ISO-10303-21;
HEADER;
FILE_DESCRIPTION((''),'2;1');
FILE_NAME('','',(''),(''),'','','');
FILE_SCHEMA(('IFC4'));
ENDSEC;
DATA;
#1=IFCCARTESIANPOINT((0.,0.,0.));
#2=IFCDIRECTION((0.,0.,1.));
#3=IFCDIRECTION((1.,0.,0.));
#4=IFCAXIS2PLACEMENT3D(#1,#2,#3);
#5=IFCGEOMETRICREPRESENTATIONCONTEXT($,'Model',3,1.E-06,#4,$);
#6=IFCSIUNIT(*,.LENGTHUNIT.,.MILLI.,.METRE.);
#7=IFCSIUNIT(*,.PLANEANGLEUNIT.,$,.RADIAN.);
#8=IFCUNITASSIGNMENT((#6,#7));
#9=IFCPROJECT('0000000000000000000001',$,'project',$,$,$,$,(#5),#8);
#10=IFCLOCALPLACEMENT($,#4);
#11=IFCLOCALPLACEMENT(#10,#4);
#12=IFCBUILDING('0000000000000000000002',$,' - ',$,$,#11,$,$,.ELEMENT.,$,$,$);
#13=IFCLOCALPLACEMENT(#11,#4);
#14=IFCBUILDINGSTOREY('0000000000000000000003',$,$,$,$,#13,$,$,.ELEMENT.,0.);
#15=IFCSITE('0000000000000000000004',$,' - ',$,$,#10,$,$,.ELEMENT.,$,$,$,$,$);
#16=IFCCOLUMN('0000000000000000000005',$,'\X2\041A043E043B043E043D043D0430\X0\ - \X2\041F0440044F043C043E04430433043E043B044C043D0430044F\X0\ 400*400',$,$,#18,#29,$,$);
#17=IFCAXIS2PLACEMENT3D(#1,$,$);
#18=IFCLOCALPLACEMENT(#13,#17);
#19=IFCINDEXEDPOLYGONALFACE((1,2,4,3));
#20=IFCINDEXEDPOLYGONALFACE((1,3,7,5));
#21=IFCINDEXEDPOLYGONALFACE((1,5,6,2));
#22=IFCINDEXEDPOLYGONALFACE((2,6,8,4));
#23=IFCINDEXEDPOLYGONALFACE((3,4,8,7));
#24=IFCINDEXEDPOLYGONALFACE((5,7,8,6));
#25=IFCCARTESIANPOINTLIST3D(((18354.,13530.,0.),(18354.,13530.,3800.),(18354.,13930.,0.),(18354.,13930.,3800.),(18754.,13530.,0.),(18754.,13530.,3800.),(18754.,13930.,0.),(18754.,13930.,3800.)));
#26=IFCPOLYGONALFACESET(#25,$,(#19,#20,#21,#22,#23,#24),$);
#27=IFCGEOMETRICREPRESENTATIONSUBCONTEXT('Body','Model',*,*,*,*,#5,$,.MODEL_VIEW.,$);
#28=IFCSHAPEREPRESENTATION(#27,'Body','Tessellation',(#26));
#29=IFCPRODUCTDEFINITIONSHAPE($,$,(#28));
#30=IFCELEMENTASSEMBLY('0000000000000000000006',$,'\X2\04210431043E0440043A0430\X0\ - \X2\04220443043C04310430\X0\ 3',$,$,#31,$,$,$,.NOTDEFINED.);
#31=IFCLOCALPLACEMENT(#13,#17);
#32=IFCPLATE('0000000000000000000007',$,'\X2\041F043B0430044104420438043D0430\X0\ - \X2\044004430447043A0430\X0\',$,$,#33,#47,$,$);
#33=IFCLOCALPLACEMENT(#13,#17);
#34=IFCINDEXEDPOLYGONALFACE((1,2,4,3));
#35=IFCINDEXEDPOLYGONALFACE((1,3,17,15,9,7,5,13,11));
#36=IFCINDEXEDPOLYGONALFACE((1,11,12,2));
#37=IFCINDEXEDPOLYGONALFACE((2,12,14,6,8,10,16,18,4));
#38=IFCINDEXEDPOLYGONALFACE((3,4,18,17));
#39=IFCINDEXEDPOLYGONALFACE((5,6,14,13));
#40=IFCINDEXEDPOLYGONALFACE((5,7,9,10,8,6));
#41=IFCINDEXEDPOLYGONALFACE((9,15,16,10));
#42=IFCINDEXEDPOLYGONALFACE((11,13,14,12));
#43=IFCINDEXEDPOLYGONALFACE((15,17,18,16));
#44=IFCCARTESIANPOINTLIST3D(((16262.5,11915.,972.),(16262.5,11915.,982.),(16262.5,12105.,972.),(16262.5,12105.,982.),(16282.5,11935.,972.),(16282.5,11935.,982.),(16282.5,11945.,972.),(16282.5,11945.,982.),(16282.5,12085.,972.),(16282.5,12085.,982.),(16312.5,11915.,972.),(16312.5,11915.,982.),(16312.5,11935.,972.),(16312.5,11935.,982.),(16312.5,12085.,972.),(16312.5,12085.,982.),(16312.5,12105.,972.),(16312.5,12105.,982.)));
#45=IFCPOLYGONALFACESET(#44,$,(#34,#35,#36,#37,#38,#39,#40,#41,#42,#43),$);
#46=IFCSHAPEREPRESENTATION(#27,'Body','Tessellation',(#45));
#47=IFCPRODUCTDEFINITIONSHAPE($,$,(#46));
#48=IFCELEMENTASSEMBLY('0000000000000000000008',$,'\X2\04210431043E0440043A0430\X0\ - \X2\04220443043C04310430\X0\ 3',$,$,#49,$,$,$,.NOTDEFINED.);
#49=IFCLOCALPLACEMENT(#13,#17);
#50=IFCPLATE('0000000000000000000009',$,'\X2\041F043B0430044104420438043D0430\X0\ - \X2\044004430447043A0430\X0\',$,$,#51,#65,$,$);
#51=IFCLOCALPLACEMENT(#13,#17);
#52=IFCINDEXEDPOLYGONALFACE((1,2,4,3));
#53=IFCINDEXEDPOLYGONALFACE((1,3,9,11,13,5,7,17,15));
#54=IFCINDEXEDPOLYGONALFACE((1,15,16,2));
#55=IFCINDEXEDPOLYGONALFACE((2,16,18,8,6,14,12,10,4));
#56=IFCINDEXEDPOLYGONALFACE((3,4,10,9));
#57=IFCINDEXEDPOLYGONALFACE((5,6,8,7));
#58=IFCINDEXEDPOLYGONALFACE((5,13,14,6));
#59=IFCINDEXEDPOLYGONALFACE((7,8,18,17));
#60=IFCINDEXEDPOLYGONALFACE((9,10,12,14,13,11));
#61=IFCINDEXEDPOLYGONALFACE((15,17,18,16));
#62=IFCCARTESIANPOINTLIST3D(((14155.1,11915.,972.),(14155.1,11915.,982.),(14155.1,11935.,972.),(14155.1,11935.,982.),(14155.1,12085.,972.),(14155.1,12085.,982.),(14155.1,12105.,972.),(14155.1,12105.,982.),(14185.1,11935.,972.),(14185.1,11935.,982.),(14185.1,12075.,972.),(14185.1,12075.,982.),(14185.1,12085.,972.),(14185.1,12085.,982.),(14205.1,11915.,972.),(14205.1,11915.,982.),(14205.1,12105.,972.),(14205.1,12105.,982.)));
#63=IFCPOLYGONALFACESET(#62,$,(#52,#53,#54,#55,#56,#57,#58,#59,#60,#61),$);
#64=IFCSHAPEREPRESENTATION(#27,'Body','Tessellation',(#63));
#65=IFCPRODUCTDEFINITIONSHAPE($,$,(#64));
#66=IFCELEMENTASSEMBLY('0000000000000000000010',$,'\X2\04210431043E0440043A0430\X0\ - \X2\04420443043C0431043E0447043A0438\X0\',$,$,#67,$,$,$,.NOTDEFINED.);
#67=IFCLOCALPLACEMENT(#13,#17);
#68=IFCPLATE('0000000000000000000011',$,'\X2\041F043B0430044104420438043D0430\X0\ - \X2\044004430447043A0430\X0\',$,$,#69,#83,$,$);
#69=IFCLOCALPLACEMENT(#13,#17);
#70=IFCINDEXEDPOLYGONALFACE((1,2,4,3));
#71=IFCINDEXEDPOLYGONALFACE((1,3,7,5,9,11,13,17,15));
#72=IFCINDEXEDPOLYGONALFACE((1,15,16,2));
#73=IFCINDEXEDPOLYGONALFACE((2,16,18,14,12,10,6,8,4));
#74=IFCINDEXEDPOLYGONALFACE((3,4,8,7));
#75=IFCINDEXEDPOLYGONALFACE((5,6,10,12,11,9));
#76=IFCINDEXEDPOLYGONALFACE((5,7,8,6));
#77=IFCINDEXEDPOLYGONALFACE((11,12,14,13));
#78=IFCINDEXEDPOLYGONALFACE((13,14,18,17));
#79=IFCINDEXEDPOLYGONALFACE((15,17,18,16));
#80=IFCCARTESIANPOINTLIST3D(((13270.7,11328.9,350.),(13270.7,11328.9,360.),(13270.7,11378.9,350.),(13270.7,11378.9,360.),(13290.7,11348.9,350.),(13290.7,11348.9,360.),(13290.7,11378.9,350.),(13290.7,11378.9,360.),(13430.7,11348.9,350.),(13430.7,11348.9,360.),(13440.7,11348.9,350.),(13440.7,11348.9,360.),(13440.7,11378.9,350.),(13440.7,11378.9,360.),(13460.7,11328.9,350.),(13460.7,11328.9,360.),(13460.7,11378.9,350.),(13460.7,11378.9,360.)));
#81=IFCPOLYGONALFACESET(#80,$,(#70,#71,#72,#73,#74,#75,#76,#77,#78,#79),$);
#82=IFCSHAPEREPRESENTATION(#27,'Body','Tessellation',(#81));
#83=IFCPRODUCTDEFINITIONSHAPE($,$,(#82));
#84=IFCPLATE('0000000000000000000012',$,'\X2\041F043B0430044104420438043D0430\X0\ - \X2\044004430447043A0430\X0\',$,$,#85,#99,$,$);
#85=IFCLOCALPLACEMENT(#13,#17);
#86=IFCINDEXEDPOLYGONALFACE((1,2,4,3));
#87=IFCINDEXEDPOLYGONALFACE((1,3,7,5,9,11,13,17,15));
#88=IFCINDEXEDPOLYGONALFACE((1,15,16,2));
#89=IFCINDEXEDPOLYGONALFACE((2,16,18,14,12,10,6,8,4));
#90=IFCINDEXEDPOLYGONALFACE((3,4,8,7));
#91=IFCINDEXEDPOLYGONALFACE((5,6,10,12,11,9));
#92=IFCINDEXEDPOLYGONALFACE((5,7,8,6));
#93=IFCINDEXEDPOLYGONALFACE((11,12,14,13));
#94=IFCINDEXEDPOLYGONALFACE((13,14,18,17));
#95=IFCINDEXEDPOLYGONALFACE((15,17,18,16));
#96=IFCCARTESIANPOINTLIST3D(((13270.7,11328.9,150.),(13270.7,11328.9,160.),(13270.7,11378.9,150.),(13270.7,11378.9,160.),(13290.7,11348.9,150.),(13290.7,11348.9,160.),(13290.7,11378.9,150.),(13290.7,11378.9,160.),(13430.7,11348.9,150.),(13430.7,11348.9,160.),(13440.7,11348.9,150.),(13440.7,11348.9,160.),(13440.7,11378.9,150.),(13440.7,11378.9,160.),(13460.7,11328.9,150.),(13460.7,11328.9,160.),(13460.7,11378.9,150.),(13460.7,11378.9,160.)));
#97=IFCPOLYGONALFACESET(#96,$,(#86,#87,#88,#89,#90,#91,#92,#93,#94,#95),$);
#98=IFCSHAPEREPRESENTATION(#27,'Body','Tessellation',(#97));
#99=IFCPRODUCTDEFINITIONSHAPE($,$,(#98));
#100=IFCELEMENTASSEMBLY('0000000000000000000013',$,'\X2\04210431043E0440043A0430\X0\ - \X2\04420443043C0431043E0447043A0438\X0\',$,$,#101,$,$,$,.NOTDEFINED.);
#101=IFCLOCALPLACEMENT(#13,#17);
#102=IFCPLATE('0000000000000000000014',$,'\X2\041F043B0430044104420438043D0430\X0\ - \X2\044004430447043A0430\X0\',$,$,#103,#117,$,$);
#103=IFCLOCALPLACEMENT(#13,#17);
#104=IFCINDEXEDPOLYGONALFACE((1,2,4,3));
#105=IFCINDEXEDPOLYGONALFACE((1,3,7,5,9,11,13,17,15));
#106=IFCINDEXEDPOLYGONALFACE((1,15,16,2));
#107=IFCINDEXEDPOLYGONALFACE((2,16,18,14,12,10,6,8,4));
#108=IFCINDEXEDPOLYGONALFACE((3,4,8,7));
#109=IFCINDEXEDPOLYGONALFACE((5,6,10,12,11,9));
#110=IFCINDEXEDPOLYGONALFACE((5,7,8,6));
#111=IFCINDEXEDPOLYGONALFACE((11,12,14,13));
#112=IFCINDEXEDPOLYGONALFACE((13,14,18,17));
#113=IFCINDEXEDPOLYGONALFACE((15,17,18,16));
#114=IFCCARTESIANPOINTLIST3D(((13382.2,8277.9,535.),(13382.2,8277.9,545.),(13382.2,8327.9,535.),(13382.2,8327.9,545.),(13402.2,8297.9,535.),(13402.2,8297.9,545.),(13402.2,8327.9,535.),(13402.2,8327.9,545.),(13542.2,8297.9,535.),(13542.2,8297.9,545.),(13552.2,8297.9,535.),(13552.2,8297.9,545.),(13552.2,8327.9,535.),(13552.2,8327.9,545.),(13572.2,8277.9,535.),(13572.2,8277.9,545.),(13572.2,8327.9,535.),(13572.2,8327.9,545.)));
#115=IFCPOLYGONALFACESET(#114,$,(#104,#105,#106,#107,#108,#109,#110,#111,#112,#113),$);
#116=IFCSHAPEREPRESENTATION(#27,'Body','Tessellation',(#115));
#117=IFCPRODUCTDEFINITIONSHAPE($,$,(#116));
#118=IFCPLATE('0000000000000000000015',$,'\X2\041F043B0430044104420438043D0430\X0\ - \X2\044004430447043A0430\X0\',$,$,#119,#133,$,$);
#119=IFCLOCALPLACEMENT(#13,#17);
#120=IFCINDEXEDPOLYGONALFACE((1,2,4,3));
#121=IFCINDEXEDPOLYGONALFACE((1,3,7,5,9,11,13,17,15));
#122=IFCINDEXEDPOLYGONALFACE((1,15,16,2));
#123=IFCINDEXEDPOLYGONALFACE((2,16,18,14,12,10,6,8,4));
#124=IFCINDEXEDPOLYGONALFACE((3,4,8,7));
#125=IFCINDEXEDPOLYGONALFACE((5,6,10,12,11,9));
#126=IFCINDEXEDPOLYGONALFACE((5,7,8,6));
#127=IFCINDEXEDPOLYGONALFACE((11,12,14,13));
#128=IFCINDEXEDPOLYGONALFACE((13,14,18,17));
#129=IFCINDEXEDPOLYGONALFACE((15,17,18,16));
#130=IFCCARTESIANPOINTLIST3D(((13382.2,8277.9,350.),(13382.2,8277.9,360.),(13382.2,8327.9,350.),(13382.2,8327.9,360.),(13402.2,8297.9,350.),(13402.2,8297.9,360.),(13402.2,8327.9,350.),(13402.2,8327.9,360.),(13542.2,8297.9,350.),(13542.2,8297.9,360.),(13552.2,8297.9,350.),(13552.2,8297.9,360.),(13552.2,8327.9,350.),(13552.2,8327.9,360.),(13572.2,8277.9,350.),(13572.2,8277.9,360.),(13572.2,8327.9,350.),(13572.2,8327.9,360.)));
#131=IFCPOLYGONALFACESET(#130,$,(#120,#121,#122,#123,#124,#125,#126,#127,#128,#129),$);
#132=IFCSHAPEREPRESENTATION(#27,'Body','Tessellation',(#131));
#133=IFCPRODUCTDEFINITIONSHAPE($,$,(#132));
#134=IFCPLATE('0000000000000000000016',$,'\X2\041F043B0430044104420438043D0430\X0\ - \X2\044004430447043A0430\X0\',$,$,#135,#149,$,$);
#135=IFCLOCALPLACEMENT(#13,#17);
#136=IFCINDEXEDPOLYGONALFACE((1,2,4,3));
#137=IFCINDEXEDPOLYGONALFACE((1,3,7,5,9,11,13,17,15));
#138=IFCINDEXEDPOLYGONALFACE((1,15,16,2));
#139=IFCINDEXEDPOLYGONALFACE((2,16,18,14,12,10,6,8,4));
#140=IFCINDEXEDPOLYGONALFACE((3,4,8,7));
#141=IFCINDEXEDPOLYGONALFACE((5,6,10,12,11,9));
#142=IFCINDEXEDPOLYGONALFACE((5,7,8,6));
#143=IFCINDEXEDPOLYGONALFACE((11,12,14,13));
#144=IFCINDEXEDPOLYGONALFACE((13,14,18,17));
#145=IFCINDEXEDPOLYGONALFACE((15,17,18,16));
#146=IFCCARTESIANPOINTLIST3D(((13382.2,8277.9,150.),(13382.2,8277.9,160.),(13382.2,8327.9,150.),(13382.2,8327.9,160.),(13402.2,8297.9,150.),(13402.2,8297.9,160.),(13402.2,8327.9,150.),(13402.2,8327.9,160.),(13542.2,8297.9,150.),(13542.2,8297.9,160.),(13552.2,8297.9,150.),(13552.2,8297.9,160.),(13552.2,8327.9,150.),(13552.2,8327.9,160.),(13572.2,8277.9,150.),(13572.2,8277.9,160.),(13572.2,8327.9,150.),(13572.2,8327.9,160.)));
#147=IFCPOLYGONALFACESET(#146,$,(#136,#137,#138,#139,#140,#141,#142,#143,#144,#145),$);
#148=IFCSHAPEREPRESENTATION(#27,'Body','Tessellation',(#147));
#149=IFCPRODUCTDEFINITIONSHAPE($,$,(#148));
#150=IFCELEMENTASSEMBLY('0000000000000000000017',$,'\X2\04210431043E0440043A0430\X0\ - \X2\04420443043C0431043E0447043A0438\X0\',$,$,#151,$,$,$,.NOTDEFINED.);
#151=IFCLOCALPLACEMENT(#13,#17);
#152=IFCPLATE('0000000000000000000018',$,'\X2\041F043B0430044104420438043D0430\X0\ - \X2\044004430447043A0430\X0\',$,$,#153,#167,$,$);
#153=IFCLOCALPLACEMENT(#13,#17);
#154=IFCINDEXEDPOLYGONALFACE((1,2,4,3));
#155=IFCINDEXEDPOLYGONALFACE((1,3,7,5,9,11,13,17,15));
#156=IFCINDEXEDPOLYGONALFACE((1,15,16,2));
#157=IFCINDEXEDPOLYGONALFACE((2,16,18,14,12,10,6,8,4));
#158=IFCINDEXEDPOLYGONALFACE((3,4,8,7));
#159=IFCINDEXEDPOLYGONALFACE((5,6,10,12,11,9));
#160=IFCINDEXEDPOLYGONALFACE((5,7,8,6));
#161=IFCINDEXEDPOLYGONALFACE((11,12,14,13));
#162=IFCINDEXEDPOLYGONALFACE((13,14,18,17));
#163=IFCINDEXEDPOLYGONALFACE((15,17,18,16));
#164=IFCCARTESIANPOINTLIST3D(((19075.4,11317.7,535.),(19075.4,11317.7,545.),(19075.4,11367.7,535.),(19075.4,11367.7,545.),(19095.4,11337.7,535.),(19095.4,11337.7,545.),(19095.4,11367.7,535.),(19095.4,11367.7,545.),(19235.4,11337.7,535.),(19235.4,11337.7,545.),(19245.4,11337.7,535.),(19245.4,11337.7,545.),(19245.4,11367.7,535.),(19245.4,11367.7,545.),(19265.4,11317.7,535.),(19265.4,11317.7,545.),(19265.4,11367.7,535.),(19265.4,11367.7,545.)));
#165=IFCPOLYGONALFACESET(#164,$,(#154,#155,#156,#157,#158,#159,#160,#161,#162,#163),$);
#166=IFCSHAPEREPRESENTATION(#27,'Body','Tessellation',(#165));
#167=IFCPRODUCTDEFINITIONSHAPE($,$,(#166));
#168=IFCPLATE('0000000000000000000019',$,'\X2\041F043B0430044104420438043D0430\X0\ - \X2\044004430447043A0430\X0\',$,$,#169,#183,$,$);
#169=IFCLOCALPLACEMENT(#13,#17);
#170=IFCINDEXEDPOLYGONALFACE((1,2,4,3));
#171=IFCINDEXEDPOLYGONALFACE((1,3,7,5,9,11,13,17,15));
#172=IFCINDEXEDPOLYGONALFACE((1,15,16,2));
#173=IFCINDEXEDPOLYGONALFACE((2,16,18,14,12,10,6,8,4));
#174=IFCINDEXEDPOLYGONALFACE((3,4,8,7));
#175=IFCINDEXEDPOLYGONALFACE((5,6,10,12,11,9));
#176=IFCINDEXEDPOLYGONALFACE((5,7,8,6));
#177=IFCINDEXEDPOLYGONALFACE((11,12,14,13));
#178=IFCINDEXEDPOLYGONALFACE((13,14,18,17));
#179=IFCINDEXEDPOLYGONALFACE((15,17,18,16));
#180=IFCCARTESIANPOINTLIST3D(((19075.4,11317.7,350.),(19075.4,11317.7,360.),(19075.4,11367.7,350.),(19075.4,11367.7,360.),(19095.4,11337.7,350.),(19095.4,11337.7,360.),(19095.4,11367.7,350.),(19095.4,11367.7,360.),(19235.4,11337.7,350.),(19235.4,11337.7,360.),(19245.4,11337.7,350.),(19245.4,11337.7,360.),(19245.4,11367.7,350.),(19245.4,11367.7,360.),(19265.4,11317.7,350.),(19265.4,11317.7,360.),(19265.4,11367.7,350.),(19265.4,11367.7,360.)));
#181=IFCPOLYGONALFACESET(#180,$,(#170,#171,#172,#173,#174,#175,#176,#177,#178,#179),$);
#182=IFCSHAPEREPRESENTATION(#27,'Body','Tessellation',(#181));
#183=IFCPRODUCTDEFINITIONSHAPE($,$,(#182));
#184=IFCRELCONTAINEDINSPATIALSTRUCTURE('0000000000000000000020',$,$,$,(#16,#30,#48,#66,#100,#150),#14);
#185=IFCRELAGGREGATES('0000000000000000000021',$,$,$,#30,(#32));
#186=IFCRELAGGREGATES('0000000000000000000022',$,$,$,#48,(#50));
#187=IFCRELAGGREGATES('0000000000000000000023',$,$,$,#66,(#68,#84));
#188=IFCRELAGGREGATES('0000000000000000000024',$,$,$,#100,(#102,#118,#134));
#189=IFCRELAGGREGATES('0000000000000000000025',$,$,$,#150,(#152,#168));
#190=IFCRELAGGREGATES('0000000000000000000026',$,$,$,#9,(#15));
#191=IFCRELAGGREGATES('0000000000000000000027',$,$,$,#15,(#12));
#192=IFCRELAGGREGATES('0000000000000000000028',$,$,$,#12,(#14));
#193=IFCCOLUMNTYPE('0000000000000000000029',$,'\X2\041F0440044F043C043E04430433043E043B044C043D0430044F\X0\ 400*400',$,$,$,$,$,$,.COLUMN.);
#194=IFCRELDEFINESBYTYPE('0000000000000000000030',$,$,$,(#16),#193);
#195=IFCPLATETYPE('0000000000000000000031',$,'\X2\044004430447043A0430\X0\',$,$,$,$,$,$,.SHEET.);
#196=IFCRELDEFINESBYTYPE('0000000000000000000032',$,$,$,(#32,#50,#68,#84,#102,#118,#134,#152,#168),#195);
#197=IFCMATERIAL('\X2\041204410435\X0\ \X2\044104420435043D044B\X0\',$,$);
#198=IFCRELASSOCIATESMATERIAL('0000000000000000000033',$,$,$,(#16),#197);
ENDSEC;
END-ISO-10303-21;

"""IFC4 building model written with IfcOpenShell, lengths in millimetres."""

from ifc_helpers import new_model, si_unit, frame, origin_with_axes, place, context, subcontext, project, spatial, line, indexed_curve, outline, extrude, source, transform, mapped, material, type_object, element, aggregate, save


model = new_model("IFC4")

# Units and contexts
model_context = context("Model", 3, precision=1e-06, world=origin_with_axes())
body_context = subcontext(model_context, "Body", "Model", "MODEL_VIEW")
ifc_project = project(units=[si_unit("LENGTHUNIT", "METRE", prefix="MILLI"), si_unit("PLANEANGLEUNIT", "RADIAN")], contexts=[model_context])

# Site, building, storey
site_placement = place(None, origin_with_axes())
site = spatial("IfcSite", under=ifc_project, at=site_placement, Name=" - ", CompositionType="ELEMENT")
building_placement = place(site_placement, origin_with_axes())
building = spatial("IfcBuilding", under=site, at=building_placement, Name=" - ", CompositionType="ELEMENT")
storey_placement = place(building_placement, origin_with_axes())
storey = spatial("IfcBuildingStorey", under=building, at=storey_placement, CompositionType="ELEMENT", Elevation=0.0)

# Column
ifc_material = material(Name="Все стены")
column_type = type_object("IfcColumnType", Name="Прямоугольная 400*400", PredefinedType="COLUMN")
shared_shape_1 = source(origin_with_axes(), body_context, "Body", "SweptSolid", [
    extrude(outline(indexed_curve([(-200.0, -200.0), (200.0, -200.0), (200.0, 200.0), (-200.0, 200.0)], segments=[line(1, 2), line(2, 3), line(3, 4), line(4, 1)])), origin_with_axes(), (0.0, 0.0, 1.0), 3800.0),
])
column_placement = place(storey_placement, frame((18554.0, 13730.0, 0.0), z_axis=(0.0, 0.0, 1.0), x_axis=(1.0, 0.0, 0.0)))
element("IfcColumn", 1, at=column_placement, inside=storey, type_object=column_type, material=ifc_material, Name="Колонна - Прямоугольная 400*400", context=body_context, shape_type="MappedRepresentation", body=[
    mapped(shared_shape_1, transform((0.0, 0.0, 0.0), x_axis=(1.0, 0.0, 0.0), y_axis=(0.0, 1.0, 0.0), z_axis=(0.0, 0.0, 1.0), scale=1.0)),
])

# Element assemblies, plates
assembly_1_placement = place(storey_placement, frame((16502.5, 12010.0, 2.0), z_axis=(0.0, 0.0, 1.0), x_axis=(0.0, -1.0, 0.0)))
assembly_1 = element("IfcElementAssembly", 2, at=assembly_1_placement, inside=storey, Name="Сборка - Тумба 3", PredefinedType="NOTDEFINED")
plate_type_1 = type_object("IfcPlateType", Name="ручка", PredefinedType="SHEET")
shared_shape_2 = source(origin_with_axes(), body_context, "Body", "SweptSolid", [
    extrude(outline(indexed_curve([(-95.0, -25.0), (-75.0, -25.0), (-75.0, 5.0), (-65.0, 5.0), (75.0, 5.0), (75.0, -25.0), (95.0, -25.0), (95.0, 25.0), (-95.0, 25.0)], segments=[line(1, 2), line(2, 3), line(3, 4), line(4, 5), line(5, 6), line(6, 7), line(7, 8), line(8, 9), line(9, 1)])), origin_with_axes(), (0.0, 0.0, 1.0), 10.0),
])
plate_1_placement = place(assembly_1_placement, frame((0.0, -215.0, 970.0), z_axis=(0.0, 0.0, 1.0), x_axis=(-1.0, 0.0, 0.0)))
plate_1 = element("IfcPlate", 3, at=plate_1_placement, type_object=plate_type_1, Name="Пластина - ручка", context=body_context, shape_type="MappedRepresentation", body=[
    mapped(shared_shape_2, transform((0.0, 0.0, 0.0), x_axis=(1.0, 0.0, 0.0), y_axis=(0.0, 1.0, 0.0), z_axis=(0.0, 0.0, 1.0), scale=1.0)),
])
aggregate(assembly_1, [plate_1])
assembly_2_placement = place(storey_placement, frame((13965.1, 12010.0, 2.0), z_axis=(0.0, 0.0, 1.0), x_axis=(0.0, 1.0, 0.0)))
assembly_2 = element("IfcElementAssembly", 4, at=assembly_2_placement, inside=storey, Name="Сборка - Тумба 3", PredefinedType="NOTDEFINED")
plate_2_placement = place(assembly_2_placement, frame((0.0, -215.0, 970.0), z_axis=(0.0, 0.0, 1.0), x_axis=(-1.0, 0.0, 0.0)))
plate_2 = element("IfcPlate", 5, at=plate_2_placement, type_object=plate_type_1, Name="Пластина - ручка", context=body_context, shape_type="MappedRepresentation", body=[
    mapped(shared_shape_2, transform((0.0, 0.0, 0.0), x_axis=(1.0, 0.0, 0.0), y_axis=(0.0, 1.0, 0.0), z_axis=(0.0, 0.0, 1.0), scale=1.0)),
])
aggregate(assembly_2, [plate_2])
assembly_3_placement = place(storey_placement, frame((13165.7, 11378.9, 0.0), z_axis=(0.0, 0.0, 1.0), x_axis=(1.0, 0.0, 0.0)))
assembly_3 = element("IfcElementAssembly", 6, at=assembly_3_placement, inside=storey, Name="Сборка - тумбочки", PredefinedType="NOTDEFINED")
plate_3_placement = place(assembly_3_placement, frame((200.0, -25.0, 350.0), z_axis=(0.0, 0.0, 1.0), x_axis=(-1.0, 0.0, 0.0)))
plate_3 = element("IfcPlate", 7, at=plate_3_placement, type_object=plate_type_1, Name="Пластина - ручка", context=body_context, shape_type="MappedRepresentation", body=[
    mapped(shared_shape_2, transform((0.0, 0.0, 0.0), x_axis=(1.0, 0.0, 0.0), y_axis=(0.0, 1.0, 0.0), z_axis=(0.0, 0.0, 1.0), scale=1.0)),
])
plate_4_placement = place(assembly_3_placement, frame((200.0, -25.0, 150.0), z_axis=(0.0, 0.0, 1.0), x_axis=(-1.0, 0.0, 0.0)))
plate_4 = element("IfcPlate", 8, at=plate_4_placement, type_object=plate_type_1, Name="Пластина - ручка", context=body_context, shape_type="MappedRepresentation", body=[
    mapped(shared_shape_2, transform((0.0, 0.0, 0.0), x_axis=(1.0, 0.0, 0.0), y_axis=(0.0, 1.0, 0.0), z_axis=(0.0, 0.0, 1.0), scale=1.0)),
])
aggregate(assembly_3, [plate_3, plate_4])
assembly_4_placement = place(storey_placement, frame((13277.2, 8327.9, 0.0), z_axis=(0.0, 0.0, 1.0), x_axis=(1.0, 0.0, 0.0)))
assembly_4 = element("IfcElementAssembly", 9, at=assembly_4_placement, inside=storey, Name="Сборка - тумбочки", PredefinedType="NOTDEFINED")
plate_5_placement = place(assembly_4_placement, frame((200.0, -25.0, 535.0), z_axis=(0.0, 0.0, 1.0), x_axis=(-1.0, 0.0, 0.0)))
plate_5 = element("IfcPlate", 10, at=plate_5_placement, type_object=plate_type_1, Name="Пластина - ручка", context=body_context, shape_type="MappedRepresentation", body=[
    mapped(shared_shape_2, transform((0.0, 0.0, 0.0), x_axis=(1.0, 0.0, 0.0), y_axis=(0.0, 1.0, 0.0), z_axis=(0.0, 0.0, 1.0), scale=1.0)),
])
plate_6_placement = place(assembly_4_placement, frame((200.0, -25.0, 350.0), z_axis=(0.0, 0.0, 1.0), x_axis=(-1.0, 0.0, 0.0)))
plate_6 = element("IfcPlate", 11, at=plate_6_placement, type_object=plate_type_1, Name="Пластина - ручка", context=body_context, shape_type="MappedRepresentation", body=[
    mapped(shared_shape_2, transform((0.0, 0.0, 0.0), x_axis=(1.0, 0.0, 0.0), y_axis=(0.0, 1.0, 0.0), z_axis=(0.0, 0.0, 1.0), scale=1.0)),
])
plate_7_placement = place(assembly_4_placement, frame((200.0, -25.0, 150.0), z_axis=(0.0, 0.0, 1.0), x_axis=(-1.0, 0.0, 0.0)))
plate_7 = element("IfcPlate", 12, at=plate_7_placement, type_object=plate_type_1, Name="Пластина - ручка", context=body_context, shape_type="MappedRepresentation", body=[
    mapped(shared_shape_2, transform((0.0, 0.0, 0.0), x_axis=(1.0, 0.0, 0.0), y_axis=(0.0, 1.0, 0.0), z_axis=(0.0, 0.0, 1.0), scale=1.0)),
])
aggregate(assembly_4, [plate_5, plate_6, plate_7])
assembly_5_placement = place(storey_placement, frame((18970.4, 11367.7, 0.0), z_axis=(0.0, 0.0, 1.0), x_axis=(1.0, 0.0, 0.0)))
assembly_5 = element("IfcElementAssembly", 13, at=assembly_5_placement, inside=storey, Name="Сборка - тумбочки", PredefinedType="NOTDEFINED")
plate_8_placement = place(assembly_5_placement, frame((200.0, -25.0, 535.0), z_axis=(0.0, 0.0, 1.0), x_axis=(-1.0, 0.0, 0.0)))
plate_8 = element("IfcPlate", 14, at=plate_8_placement, type_object=plate_type_1, Name="Пластина - ручка", context=body_context, shape_type="MappedRepresentation", body=[
    mapped(shared_shape_2, transform((0.0, 0.0, 0.0), x_axis=(1.0, 0.0, 0.0), y_axis=(0.0, 1.0, 0.0), z_axis=(0.0, 0.0, 1.0), scale=1.0)),
])
plate_9_placement = place(assembly_5_placement, frame((200.0, -25.0, 350.0), z_axis=(0.0, 0.0, 1.0), x_axis=(-1.0, 0.0, 0.0)))
plate_9 = element("IfcPlate", 15, at=plate_9_placement, type_object=plate_type_1, Name="Пластина - ручка", context=body_context, shape_type="MappedRepresentation", body=[
    mapped(shared_shape_2, transform((0.0, 0.0, 0.0), x_axis=(1.0, 0.0, 0.0), y_axis=(0.0, 1.0, 0.0), z_axis=(0.0, 0.0, 1.0), scale=1.0)),
])
aggregate(assembly_5, [plate_8, plate_9])

save(model, "model.ifc")
